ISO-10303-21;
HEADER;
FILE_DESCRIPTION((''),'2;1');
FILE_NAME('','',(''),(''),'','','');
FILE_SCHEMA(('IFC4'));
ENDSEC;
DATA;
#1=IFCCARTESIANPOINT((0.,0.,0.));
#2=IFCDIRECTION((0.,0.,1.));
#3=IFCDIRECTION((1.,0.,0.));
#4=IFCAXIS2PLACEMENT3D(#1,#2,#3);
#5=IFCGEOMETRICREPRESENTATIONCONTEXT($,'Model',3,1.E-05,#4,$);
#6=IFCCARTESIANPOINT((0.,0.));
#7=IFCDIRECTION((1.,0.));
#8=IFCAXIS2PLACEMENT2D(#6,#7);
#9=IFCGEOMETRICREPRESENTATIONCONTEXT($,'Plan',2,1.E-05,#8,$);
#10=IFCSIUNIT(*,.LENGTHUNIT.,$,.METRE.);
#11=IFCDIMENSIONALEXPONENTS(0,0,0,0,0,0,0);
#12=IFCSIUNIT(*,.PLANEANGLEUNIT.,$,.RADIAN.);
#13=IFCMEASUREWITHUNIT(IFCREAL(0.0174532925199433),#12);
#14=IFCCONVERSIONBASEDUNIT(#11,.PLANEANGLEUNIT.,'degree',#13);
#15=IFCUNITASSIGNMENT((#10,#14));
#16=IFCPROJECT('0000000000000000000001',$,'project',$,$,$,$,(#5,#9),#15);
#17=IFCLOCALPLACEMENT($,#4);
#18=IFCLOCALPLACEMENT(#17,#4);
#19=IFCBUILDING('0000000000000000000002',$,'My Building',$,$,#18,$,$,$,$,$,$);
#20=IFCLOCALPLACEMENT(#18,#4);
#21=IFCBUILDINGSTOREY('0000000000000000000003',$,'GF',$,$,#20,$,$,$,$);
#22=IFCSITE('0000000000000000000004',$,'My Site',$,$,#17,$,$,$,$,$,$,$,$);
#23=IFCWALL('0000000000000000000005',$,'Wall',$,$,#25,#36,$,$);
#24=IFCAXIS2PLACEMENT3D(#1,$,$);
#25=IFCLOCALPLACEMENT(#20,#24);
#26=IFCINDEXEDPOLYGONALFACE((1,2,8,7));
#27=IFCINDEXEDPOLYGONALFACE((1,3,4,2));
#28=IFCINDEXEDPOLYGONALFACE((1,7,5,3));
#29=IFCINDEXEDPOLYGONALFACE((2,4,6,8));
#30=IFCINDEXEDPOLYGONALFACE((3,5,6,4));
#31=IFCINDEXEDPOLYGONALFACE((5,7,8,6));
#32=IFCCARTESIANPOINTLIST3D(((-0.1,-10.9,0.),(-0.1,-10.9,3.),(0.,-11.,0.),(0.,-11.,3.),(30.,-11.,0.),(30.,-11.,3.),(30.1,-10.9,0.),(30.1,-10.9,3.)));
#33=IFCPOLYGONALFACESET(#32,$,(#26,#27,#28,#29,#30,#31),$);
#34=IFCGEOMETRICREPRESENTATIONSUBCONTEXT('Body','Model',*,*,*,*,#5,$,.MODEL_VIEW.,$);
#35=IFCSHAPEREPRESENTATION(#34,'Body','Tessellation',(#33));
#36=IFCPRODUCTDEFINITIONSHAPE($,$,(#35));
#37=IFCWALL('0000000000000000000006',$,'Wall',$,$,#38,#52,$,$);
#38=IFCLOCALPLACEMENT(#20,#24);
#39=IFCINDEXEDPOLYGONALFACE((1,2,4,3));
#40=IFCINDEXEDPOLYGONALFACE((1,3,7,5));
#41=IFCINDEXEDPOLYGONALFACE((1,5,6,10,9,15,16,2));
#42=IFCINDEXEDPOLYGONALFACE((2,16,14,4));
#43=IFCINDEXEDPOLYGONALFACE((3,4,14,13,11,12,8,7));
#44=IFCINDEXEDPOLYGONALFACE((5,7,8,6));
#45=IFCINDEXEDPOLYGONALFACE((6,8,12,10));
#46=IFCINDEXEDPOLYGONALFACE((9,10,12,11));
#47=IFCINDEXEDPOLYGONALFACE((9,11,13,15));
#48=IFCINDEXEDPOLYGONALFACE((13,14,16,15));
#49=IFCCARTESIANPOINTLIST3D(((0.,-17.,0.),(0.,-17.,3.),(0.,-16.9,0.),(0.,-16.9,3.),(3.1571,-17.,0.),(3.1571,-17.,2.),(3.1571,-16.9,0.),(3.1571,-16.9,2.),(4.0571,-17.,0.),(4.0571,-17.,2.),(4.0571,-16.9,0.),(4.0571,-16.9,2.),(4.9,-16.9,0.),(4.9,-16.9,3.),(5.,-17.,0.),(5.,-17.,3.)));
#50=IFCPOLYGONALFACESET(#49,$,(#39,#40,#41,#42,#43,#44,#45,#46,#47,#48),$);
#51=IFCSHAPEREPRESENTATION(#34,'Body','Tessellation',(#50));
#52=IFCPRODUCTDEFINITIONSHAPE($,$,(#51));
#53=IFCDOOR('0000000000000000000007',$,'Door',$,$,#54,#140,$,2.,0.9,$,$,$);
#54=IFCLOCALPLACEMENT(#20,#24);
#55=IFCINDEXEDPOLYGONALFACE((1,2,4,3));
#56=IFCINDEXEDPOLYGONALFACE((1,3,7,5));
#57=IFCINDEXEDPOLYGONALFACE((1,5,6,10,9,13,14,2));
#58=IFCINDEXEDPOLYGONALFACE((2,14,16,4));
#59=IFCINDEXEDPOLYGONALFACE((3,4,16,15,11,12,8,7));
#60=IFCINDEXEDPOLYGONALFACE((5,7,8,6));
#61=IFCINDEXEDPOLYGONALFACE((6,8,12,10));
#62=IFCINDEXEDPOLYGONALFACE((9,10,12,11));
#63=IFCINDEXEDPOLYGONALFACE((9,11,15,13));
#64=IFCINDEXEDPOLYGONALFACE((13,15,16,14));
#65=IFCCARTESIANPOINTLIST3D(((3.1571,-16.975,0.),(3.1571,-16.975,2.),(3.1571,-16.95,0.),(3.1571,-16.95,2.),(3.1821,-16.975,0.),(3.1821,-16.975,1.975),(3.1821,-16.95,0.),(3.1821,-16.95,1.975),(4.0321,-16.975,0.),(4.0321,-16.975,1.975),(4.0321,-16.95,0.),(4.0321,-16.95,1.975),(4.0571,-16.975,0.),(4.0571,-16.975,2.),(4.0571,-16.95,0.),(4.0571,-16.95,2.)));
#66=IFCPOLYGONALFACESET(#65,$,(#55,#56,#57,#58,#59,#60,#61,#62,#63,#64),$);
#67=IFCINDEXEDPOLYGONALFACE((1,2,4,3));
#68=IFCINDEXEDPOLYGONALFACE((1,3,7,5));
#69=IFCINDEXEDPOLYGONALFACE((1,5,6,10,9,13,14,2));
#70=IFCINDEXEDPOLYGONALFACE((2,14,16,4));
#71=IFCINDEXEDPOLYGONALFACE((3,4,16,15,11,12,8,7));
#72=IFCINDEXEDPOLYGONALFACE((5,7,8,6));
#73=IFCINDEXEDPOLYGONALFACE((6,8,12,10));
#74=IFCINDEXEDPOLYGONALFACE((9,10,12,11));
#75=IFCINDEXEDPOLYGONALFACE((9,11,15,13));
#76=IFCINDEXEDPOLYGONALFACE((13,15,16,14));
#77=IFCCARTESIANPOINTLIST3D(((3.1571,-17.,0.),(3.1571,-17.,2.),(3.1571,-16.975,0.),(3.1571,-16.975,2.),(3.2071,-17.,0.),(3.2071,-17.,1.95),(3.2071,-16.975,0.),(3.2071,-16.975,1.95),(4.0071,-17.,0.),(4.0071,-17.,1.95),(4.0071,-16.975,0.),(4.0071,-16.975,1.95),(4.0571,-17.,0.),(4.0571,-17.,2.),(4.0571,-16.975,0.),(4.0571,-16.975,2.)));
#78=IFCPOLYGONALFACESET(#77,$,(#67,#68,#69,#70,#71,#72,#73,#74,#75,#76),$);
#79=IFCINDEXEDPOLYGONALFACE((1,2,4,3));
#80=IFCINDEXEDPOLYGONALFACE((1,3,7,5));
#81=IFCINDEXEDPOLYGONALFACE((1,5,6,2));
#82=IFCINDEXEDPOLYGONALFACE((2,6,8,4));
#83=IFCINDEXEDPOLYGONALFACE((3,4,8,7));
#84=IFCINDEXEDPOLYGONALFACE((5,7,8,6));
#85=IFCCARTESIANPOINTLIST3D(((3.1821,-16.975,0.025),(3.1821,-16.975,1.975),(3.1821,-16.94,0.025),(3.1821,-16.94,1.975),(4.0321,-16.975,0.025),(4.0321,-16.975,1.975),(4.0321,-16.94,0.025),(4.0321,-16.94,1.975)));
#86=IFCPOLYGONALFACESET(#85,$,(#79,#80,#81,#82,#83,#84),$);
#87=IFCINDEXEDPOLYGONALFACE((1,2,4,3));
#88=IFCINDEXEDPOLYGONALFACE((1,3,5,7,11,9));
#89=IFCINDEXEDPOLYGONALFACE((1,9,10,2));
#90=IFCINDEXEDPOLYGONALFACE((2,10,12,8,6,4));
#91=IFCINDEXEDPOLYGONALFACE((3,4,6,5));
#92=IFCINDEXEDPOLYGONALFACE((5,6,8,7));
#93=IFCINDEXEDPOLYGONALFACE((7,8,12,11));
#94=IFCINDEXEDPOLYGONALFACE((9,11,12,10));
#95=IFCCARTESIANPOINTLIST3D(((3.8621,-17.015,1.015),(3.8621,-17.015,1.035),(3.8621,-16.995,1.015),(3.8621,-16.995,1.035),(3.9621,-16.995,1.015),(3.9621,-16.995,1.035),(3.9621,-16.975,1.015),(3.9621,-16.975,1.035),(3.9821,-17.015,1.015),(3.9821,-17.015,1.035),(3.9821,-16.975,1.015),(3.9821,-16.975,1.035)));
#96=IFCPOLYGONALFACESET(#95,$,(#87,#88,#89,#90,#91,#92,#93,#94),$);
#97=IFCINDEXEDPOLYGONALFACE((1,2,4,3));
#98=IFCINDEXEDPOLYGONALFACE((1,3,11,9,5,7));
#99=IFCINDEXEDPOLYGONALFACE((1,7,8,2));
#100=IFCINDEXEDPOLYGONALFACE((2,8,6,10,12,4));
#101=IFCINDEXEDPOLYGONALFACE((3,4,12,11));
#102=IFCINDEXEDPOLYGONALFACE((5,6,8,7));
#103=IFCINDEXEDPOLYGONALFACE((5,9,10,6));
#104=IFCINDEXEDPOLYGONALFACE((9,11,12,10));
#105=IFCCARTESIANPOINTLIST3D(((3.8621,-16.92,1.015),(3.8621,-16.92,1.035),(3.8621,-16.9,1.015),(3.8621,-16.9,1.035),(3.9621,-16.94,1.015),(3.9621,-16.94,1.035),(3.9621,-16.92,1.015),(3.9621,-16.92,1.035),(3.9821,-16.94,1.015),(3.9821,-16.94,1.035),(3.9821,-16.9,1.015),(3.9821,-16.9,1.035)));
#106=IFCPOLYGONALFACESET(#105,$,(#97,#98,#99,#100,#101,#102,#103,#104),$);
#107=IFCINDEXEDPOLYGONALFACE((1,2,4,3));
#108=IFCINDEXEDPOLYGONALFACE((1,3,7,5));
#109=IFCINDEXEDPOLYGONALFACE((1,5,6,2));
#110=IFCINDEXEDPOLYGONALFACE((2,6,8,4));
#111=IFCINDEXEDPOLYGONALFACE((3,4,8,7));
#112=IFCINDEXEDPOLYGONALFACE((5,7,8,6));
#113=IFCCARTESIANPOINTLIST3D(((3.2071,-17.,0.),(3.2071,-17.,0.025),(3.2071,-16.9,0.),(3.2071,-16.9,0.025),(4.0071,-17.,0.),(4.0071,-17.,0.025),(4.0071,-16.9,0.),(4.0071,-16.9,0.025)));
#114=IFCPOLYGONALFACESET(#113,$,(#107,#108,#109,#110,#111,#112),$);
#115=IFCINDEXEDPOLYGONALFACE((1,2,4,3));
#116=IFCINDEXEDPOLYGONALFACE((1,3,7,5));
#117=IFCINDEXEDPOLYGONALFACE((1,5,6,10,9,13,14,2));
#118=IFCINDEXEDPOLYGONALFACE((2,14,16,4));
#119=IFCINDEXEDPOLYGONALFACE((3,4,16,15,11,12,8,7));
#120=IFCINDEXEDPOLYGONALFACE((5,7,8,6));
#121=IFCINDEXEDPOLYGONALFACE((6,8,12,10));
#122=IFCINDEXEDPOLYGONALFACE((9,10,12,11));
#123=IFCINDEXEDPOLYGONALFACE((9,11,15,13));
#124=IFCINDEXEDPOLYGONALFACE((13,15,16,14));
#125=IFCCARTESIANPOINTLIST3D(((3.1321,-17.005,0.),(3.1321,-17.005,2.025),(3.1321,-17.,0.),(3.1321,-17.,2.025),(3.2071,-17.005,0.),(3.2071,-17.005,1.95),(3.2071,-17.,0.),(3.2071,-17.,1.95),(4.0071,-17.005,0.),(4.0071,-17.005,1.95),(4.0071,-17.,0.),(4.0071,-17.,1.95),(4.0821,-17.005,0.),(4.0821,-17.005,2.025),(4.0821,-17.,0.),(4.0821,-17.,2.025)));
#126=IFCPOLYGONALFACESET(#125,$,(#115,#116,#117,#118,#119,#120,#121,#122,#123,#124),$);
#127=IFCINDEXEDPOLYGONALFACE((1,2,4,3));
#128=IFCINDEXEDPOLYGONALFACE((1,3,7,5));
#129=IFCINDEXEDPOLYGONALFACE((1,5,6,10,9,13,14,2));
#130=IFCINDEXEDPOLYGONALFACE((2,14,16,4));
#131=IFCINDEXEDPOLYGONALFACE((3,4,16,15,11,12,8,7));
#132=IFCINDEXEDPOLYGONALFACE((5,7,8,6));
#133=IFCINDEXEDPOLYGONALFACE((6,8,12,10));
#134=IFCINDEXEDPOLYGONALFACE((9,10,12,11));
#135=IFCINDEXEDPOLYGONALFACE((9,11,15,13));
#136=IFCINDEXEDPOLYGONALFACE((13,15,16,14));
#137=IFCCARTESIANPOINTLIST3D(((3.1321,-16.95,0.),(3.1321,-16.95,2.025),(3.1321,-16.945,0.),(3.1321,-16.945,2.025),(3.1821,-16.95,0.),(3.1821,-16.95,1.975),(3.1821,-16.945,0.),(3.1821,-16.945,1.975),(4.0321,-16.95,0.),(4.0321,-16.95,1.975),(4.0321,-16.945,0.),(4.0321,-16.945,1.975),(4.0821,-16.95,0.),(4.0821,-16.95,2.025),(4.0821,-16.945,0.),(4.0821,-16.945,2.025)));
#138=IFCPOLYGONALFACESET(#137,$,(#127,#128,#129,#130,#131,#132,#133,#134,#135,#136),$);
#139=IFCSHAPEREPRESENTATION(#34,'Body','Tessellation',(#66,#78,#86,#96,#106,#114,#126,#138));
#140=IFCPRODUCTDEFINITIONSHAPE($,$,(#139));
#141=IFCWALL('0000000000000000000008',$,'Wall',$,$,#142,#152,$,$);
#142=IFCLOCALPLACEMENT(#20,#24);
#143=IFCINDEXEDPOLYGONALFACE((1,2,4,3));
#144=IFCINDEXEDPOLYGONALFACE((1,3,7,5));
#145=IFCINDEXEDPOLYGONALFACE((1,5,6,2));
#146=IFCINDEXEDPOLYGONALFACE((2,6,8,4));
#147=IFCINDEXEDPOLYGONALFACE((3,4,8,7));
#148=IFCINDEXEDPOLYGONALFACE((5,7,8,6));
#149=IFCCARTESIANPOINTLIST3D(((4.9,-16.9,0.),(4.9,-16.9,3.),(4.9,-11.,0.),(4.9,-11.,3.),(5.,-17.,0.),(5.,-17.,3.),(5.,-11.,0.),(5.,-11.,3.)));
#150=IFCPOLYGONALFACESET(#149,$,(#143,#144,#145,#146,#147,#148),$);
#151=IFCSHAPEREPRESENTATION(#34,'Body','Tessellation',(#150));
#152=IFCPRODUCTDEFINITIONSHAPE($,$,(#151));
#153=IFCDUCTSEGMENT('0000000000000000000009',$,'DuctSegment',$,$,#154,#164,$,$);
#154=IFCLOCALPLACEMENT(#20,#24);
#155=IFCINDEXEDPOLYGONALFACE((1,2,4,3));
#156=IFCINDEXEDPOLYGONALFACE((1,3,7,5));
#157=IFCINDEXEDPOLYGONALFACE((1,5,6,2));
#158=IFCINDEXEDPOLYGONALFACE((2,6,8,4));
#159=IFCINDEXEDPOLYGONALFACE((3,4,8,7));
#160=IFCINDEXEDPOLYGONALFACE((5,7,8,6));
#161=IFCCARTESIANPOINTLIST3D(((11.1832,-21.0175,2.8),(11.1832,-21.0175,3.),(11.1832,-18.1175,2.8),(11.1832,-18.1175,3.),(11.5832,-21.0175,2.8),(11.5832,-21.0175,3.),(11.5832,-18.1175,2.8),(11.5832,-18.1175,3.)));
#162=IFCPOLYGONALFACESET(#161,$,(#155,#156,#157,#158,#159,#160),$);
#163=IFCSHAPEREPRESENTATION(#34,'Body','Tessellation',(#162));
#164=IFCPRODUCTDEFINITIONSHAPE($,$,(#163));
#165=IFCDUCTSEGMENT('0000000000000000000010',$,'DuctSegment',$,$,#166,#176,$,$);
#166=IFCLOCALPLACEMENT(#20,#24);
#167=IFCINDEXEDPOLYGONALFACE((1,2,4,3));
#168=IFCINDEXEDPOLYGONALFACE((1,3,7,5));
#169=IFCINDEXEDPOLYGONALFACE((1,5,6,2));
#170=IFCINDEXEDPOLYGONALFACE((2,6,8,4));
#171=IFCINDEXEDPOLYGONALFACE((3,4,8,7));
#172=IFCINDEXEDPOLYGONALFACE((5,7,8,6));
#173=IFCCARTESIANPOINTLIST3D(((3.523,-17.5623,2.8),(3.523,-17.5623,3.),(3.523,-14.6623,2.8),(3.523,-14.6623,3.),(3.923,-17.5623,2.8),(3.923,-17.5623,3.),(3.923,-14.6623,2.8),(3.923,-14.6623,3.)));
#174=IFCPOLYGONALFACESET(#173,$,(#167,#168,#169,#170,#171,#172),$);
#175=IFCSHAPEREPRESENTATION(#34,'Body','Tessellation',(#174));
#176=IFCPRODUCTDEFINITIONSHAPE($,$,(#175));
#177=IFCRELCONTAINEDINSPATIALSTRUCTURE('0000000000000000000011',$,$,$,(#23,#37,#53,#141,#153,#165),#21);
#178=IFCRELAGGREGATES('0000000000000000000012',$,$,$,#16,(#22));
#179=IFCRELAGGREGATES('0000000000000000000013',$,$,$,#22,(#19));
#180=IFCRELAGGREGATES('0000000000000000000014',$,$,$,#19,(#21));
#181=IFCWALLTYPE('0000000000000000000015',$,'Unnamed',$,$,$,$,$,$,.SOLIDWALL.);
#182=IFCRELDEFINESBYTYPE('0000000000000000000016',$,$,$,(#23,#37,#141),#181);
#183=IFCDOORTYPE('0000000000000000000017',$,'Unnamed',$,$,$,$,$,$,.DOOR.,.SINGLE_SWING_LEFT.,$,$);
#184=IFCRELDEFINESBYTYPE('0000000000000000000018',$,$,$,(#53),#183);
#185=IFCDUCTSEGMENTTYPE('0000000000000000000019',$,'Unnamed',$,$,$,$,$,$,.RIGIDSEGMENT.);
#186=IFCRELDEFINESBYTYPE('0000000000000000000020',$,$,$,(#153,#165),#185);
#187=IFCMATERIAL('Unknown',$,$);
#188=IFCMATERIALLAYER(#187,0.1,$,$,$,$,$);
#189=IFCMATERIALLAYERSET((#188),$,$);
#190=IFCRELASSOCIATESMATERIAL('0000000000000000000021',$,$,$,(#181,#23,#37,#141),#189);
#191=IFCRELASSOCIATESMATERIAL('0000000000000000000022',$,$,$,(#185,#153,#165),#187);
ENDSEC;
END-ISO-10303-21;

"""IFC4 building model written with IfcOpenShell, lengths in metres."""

from ifc_helpers import new_model, entity, si_unit, converted_unit, frame, origin_with_axes, origin_2d_with_axis, place, context, subcontext, project, spatial, line, indexed_curve, rectangle, outline, extrude, shape, source, transform, mapped, material, layer, layer_set, layer_usage, material_profile, profile_set, profile_usage, type_object, type_shapes, element, fill, save


model = new_model("IFC4")

# Units and contexts
model_context = context("Model", 3, precision=1e-05, world=origin_with_axes())
plan_context = context("Plan", 2, precision=1e-05, world=origin_2d_with_axis())
body_context_1 = subcontext(model_context, "Body", "Model", "MODEL_VIEW")
body_context_2 = subcontext(plan_context, "Body", "Plan", "PLAN_VIEW")
ifc_project = project(units=[si_unit("LENGTHUNIT", "METRE"), converted_unit("PLANEANGLEUNIT", "degree", entity("IfcReal", 0.0174532925199433), si_unit("PLANEANGLEUNIT", "RADIAN"), dimensions=[0, 0, 0, 0, 0, 0, 0])], contexts=[model_context, plan_context])

# Site, building, storey
site_placement = place(None, origin_with_axes())
site = spatial("IfcSite", under=ifc_project, at=site_placement, Name="My Site")
building_placement = place(site_placement, origin_with_axes())
building = spatial("IfcBuilding", under=site, at=building_placement, Name="My Building")
storey_placement = place(building_placement, origin_with_axes())
storey = spatial("IfcBuildingStorey", under=building, at=storey_placement, Name="GF")

# Wall
ifc_material = material(Name="Unknown")
ifc_layer = layer(ifc_material, 0.1)
ifc_layer_set = layer_set([ifc_layer])
ifc_layer_usage_1 = layer_usage(ifc_layer_set, "AXIS2", "POSITIVE", 0.0)
wall_type = type_object("IfcWallType", Name="Unnamed", PredefinedType="SOLIDWALL", material=ifc_layer_set)
wall_1_placement = place(storey_placement, frame((0.0, -11.0, 0.0), z_axis=(0.0, 0.0, 1.0), x_axis=(1.0, 0.0, 0.0)))
element("IfcWall", 1, at=wall_1_placement, inside=storey, type_object=wall_type, material=ifc_layer_usage_1, Name="Wall", context=body_context_1, shape_type="SweptSolid", body=[
    extrude(outline(indexed_curve([(0.0, 0.0), (-0.1, 0.1), (30.1, 0.1), (30.0, 0.0)], segments=[line(1, 2, 3, 4, 1)])), origin_with_axes(), (0.0, 0.0, 1.0), 3.0),
])

# Wall, opening, door
ifc_layer_usage_2 = layer_usage(ifc_layer_set, "AXIS2", "POSITIVE", 0.0)
wall_2_placement = place(storey_placement, frame((0.0, -17.0, 0.0), z_axis=(0.0, 0.0, 1.0), x_axis=(1.0, 0.0, 0.0)))
wall_2 = element("IfcWall", 2, at=wall_2_placement, inside=storey, type_object=wall_type, material=ifc_layer_usage_2, Name="Wall", context=body_context_1, shape_type="SweptSolid", body=[
    extrude(outline(indexed_curve([(0.0, 0.0), (0.0, 0.1), (4.9, 0.1), (5.0, 0.0)], segments=[line(1, 2, 3, 4, 1)])), origin_with_axes(), (0.0, 0.0, 1.0), 3.0),
])
shared_shape_1 = source(origin_with_axes(), body_context_1, "Body", "SweptSolid", [
    extrude(outline(indexed_curve([(0.0, 0.0), (0.9, 0.0), (0.9, 2.0), (0.0, 2.0)], segments=[line(1, 2, 3, 4, 1)])), frame((0.0, -0.6, 0.0), z_axis=(0.0, -1.0, 0.0), x_axis=(1.0, 0.0, 0.0)), (0.0, 0.0, -1.0), 1.2),
])
opening_1_placement = place(wall_2_placement, frame((3.1571, 0.0, 0.0), z_axis=(0.0, 0.0, 1.0), x_axis=(1.0, 0.0, 0.0)))
opening_1 = element("IfcOpeningElement", 3, at=opening_1_placement, cuts=wall_2, PredefinedType="OPENING", context=body_context_1, shape_type="MappedRepresentation", body=[
    mapped(shared_shape_1, transform((0.0, 0.0, 0.0), x_axis=(1.0, 0.0, 0.0), y_axis=(0.0, 1.0, 0.0), z_axis=(0.0, 0.0, 1.0), scale=1.0)),
])
door_type = type_object("IfcDoorType", Name="Unnamed", OperationType="SINGLE_SWING_LEFT", PredefinedType="DOOR")
shared_shape_2 = source(origin_with_axes(), body_context_1, "Body", "SweptSolid", [
    extrude(outline(indexed_curve([(0.0, 0.0), (0.0, 2.0), (0.9, 2.0), (0.9, 0.0), (0.875, 0.0), (0.875, 1.975), (0.025, 1.975), (0.025, 0.0)], segments=[line(1, 2, 3, 4, 5, 6, 7, 8, 1)])), frame((0.0, 0.025, 0.0), z_axis=(0.0, -1.0, 0.0), x_axis=(1.0, 0.0, 0.0)), (0.0, 0.0, -1.0), 0.025),
    extrude(outline(indexed_curve([(0.0, 0.0), (0.0, 2.0), (0.9, 2.0), (0.9, 0.0), (0.85, 0.0), (0.85, 1.95), (0.05, 1.95), (0.05, 0.0)], segments=[line(1, 2, 3, 4, 5, 6, 7, 8, 1)])), frame((0.0, 0.0, 0.0), z_axis=(0.0, -1.0, 0.0), x_axis=(1.0, 0.0, 0.0)), (0.0, 0.0, -1.0), 0.025),
    extrude(outline(indexed_curve([(0.0, 0.0), (0.85, 0.0), (0.85, 0.035), (0.0, 0.035)], segments=[line(1, 2, 3, 4, 1)])), frame((0.025, 0.025, 0.025), z_axis=(0.0, 0.0, 1.0), x_axis=(1.0, 0.0, 0.0)), (0.0, 0.0, 1.0), 1.95),
    extrude(outline(indexed_curve([(0.0, 0.0), (0.0, -0.04), (-0.12, -0.04), (-0.12, -0.02), (-0.02, -0.02), (-0.02, 0.0)], segments=[line(1, 2, 3, 4, 5, 6, 1)])), frame((0.825, 0.025, 1.015), z_axis=(0.0, 0.0, 1.0), x_axis=(1.0, 0.0, 0.0)), (0.0, 0.0, 1.0), 0.02),
    extrude(outline(indexed_curve([(0.0, 0.0), (0.0, 0.04), (-0.12, 0.04), (-0.12, 0.02), (-0.02, 0.02), (-0.02, 0.0)], segments=[line(1, 2, 3, 4, 5, 6, 1)])), frame((0.825, 0.06, 1.015), z_axis=(0.0, 0.0, 1.0), x_axis=(1.0, 0.0, 0.0)), (0.0, 0.0, 1.0), 0.02),
    extrude(outline(indexed_curve([(0.0, 0.0), (0.8, 0.0), (0.8, 0.1), (0.0, 0.1)], segments=[line(1, 2, 3, 4, 1)])), frame((0.05, 0.0, 0.0), z_axis=(0.0, 0.0, 1.0), x_axis=(1.0, 0.0, 0.0)), (0.0, 0.0, 1.0), 0.025),
    extrude(outline(indexed_curve([(0.0, 0.0), (0.0, 2.025), (0.95, 2.025), (0.95, 0.0), (0.875, 0.0), (0.875, 1.95), (0.075, 1.95), (0.075, 0.0)], segments=[line(1, 2, 3, 4, 5, 6, 7, 8, 1)])), frame((-0.025, -0.005, 0.0), z_axis=(0.0, -1.0, 0.0), x_axis=(1.0, 0.0, 0.0)), (0.0, 0.0, -1.0), 0.005),
    extrude(outline(indexed_curve([(0.0, 0.0), (0.0, 2.025), (0.95, 2.025), (0.95, 0.0), (0.9, 0.0), (0.9, 1.975), (0.05, 1.975), (0.05, 0.0)], segments=[line(1, 2, 3, 4, 5, 6, 7, 8, 1)])), frame((-0.025, 0.05, 0.0), z_axis=(0.0, -1.0, 0.0), x_axis=(1.0, 0.0, 0.0)), (0.0, 0.0, -1.0), 0.005),
])
shared_shape_3 = source(origin_with_axes(), body_context_2, "Body", "Curve2D", [
    entity("IfcIndexedPolyCurve", entity("IfcCartesianPointList2D", [[0.0, 0.0], [0.0, 0.05], [0.025, 0.05], [0.025, 0.025], [0.05, 0.025], [0.05, 0.0]]), [entity("IfcLineIndex", [1, 2, 3, 4, 5, 6, 1])]),
    entity("IfcIndexedPolyCurve", entity("IfcCartesianPointList2D", [[0.9, 0.0], [0.9, 0.05], [0.875, 0.05], [0.875, 0.025], [0.85, 0.025], [0.85, 0.0]]), [entity("IfcLineIndex", [1, 2, 3, 4, 5, 6, 1])]),
    entity("IfcTrimmedCurve", entity("IfcEllipse", entity("IfcAxis2Placement2D", entity("IfcCartesianPoint", [0.06, 0.05]), entity("IfcDirection", [1.0, 0.0])), 0.815, 0.85), [entity("IfcCartesianPoint", [0.875, 0.05])], [entity("IfcCartesianPoint", [0.06, 0.9])], True, "CARTESIAN"),
    entity("IfcIndexedPolyCurve", entity("IfcCartesianPointList2D", [[0.025, 0.05], [0.06, 0.05], [0.06, 0.9], [0.025, 0.9]]), [entity("IfcLineIndex", [1, 2, 3, 4, 1])]),
])
type_shapes(door_type, [shared_shape_2, shared_shape_3])
door_1_placement = place(opening_1_placement, origin_with_axes())
door_1 = element("IfcDoor", 4, at=door_1_placement, inside=storey, type_object=door_type, Name="Door", OverallHeight=2.0, OverallWidth=0.9, shapes=[
    shape(body_context_1, "Body", "MappedRepresentation", [mapped(shared_shape_2, transform((0.0, 0.0, 0.0), x_axis=(1.0, 0.0, 0.0), y_axis=(0.0, 1.0, 0.0), z_axis=(0.0, 0.0, 1.0), scale=1.0))]),
    shape(body_context_2, "Body", "MappedRepresentation", [mapped(shared_shape_3, transform((0.0, 0.0, 0.0), x_axis=(1.0, 0.0, 0.0), y_axis=(0.0, 1.0, 0.0), z_axis=(0.0, 0.0, 1.0), scale=1.0))]),
])
fill(opening_1, door_1)

# Wall
ifc_layer_usage_3 = layer_usage(ifc_layer_set, "AXIS2", "POSITIVE", 0.0)
wall_3_placement = place(storey_placement, frame((5.0, -17.0, 0.0), z_axis=(0.0, 0.0, 1.0), x_axis=(0.0, 1.0, 0.0)))
element("IfcWall", 5, at=wall_3_placement, inside=storey, type_object=wall_type, material=ifc_layer_usage_3, Name="Wall", context=body_context_1, shape_type="SweptSolid", body=[
    extrude(outline(indexed_curve([(0.0, 0.0), (0.1, 0.1), (6.0, 0.1), (6.0, 0.0)], segments=[line(1, 2, 3, 4, 1)])), origin_with_axes(), (0.0, 0.0, 1.0), 3.0),
])

# Duct segments
ifc_material_profile_1 = material_profile(ifc_material, rectangle(XDim=0.4, YDim=0.2))
ifc_profile_set_1 = profile_set([ifc_material_profile_1])
ifc_profile_usage_1 = profile_usage(ifc_profile_set_1, cardinal=5)
duct_segment_type = type_object("IfcDuctSegmentType", Name="Unnamed", PredefinedType="RIGIDSEGMENT", material=ifc_profile_set_1)
duct_segment_1_placement = place(storey_placement, frame((11.3832, -18.1175, 2.9), z_axis=(0.0, -1.0, 0.0), x_axis=(1.0, 0.0, 0.0)))
element("IfcDuctSegment", 6, at=duct_segment_1_placement, inside=storey, type_object=duct_segment_type, material=ifc_profile_usage_1, Name="DuctSegment", context=body_context_1, shape_type="SweptSolid", body=[
    extrude(rectangle(XDim=0.4, YDim=0.2), origin_with_axes(), (0.0, 0.0, 1.0), 2.9),
])
ifc_profile_usage_2 = profile_usage(ifc_profile_set_1, cardinal=5)
duct_segment_2_placement = place(storey_placement, frame((3.723, -14.6623, 2.9), z_axis=(0.0, -1.0, 0.0), x_axis=(1.0, 0.0, 0.0)))
element("IfcDuctSegment", 7, at=duct_segment_2_placement, inside=storey, type_object=duct_segment_type, material=ifc_profile_usage_2, Name="DuctSegment", context=body_context_1, shape_type="SweptSolid", body=[
    extrude(rectangle(XDim=0.4, YDim=0.2), origin_with_axes(), (0.0, 0.0, 1.0), 2.9),
])

save(model, "model.ifc")
